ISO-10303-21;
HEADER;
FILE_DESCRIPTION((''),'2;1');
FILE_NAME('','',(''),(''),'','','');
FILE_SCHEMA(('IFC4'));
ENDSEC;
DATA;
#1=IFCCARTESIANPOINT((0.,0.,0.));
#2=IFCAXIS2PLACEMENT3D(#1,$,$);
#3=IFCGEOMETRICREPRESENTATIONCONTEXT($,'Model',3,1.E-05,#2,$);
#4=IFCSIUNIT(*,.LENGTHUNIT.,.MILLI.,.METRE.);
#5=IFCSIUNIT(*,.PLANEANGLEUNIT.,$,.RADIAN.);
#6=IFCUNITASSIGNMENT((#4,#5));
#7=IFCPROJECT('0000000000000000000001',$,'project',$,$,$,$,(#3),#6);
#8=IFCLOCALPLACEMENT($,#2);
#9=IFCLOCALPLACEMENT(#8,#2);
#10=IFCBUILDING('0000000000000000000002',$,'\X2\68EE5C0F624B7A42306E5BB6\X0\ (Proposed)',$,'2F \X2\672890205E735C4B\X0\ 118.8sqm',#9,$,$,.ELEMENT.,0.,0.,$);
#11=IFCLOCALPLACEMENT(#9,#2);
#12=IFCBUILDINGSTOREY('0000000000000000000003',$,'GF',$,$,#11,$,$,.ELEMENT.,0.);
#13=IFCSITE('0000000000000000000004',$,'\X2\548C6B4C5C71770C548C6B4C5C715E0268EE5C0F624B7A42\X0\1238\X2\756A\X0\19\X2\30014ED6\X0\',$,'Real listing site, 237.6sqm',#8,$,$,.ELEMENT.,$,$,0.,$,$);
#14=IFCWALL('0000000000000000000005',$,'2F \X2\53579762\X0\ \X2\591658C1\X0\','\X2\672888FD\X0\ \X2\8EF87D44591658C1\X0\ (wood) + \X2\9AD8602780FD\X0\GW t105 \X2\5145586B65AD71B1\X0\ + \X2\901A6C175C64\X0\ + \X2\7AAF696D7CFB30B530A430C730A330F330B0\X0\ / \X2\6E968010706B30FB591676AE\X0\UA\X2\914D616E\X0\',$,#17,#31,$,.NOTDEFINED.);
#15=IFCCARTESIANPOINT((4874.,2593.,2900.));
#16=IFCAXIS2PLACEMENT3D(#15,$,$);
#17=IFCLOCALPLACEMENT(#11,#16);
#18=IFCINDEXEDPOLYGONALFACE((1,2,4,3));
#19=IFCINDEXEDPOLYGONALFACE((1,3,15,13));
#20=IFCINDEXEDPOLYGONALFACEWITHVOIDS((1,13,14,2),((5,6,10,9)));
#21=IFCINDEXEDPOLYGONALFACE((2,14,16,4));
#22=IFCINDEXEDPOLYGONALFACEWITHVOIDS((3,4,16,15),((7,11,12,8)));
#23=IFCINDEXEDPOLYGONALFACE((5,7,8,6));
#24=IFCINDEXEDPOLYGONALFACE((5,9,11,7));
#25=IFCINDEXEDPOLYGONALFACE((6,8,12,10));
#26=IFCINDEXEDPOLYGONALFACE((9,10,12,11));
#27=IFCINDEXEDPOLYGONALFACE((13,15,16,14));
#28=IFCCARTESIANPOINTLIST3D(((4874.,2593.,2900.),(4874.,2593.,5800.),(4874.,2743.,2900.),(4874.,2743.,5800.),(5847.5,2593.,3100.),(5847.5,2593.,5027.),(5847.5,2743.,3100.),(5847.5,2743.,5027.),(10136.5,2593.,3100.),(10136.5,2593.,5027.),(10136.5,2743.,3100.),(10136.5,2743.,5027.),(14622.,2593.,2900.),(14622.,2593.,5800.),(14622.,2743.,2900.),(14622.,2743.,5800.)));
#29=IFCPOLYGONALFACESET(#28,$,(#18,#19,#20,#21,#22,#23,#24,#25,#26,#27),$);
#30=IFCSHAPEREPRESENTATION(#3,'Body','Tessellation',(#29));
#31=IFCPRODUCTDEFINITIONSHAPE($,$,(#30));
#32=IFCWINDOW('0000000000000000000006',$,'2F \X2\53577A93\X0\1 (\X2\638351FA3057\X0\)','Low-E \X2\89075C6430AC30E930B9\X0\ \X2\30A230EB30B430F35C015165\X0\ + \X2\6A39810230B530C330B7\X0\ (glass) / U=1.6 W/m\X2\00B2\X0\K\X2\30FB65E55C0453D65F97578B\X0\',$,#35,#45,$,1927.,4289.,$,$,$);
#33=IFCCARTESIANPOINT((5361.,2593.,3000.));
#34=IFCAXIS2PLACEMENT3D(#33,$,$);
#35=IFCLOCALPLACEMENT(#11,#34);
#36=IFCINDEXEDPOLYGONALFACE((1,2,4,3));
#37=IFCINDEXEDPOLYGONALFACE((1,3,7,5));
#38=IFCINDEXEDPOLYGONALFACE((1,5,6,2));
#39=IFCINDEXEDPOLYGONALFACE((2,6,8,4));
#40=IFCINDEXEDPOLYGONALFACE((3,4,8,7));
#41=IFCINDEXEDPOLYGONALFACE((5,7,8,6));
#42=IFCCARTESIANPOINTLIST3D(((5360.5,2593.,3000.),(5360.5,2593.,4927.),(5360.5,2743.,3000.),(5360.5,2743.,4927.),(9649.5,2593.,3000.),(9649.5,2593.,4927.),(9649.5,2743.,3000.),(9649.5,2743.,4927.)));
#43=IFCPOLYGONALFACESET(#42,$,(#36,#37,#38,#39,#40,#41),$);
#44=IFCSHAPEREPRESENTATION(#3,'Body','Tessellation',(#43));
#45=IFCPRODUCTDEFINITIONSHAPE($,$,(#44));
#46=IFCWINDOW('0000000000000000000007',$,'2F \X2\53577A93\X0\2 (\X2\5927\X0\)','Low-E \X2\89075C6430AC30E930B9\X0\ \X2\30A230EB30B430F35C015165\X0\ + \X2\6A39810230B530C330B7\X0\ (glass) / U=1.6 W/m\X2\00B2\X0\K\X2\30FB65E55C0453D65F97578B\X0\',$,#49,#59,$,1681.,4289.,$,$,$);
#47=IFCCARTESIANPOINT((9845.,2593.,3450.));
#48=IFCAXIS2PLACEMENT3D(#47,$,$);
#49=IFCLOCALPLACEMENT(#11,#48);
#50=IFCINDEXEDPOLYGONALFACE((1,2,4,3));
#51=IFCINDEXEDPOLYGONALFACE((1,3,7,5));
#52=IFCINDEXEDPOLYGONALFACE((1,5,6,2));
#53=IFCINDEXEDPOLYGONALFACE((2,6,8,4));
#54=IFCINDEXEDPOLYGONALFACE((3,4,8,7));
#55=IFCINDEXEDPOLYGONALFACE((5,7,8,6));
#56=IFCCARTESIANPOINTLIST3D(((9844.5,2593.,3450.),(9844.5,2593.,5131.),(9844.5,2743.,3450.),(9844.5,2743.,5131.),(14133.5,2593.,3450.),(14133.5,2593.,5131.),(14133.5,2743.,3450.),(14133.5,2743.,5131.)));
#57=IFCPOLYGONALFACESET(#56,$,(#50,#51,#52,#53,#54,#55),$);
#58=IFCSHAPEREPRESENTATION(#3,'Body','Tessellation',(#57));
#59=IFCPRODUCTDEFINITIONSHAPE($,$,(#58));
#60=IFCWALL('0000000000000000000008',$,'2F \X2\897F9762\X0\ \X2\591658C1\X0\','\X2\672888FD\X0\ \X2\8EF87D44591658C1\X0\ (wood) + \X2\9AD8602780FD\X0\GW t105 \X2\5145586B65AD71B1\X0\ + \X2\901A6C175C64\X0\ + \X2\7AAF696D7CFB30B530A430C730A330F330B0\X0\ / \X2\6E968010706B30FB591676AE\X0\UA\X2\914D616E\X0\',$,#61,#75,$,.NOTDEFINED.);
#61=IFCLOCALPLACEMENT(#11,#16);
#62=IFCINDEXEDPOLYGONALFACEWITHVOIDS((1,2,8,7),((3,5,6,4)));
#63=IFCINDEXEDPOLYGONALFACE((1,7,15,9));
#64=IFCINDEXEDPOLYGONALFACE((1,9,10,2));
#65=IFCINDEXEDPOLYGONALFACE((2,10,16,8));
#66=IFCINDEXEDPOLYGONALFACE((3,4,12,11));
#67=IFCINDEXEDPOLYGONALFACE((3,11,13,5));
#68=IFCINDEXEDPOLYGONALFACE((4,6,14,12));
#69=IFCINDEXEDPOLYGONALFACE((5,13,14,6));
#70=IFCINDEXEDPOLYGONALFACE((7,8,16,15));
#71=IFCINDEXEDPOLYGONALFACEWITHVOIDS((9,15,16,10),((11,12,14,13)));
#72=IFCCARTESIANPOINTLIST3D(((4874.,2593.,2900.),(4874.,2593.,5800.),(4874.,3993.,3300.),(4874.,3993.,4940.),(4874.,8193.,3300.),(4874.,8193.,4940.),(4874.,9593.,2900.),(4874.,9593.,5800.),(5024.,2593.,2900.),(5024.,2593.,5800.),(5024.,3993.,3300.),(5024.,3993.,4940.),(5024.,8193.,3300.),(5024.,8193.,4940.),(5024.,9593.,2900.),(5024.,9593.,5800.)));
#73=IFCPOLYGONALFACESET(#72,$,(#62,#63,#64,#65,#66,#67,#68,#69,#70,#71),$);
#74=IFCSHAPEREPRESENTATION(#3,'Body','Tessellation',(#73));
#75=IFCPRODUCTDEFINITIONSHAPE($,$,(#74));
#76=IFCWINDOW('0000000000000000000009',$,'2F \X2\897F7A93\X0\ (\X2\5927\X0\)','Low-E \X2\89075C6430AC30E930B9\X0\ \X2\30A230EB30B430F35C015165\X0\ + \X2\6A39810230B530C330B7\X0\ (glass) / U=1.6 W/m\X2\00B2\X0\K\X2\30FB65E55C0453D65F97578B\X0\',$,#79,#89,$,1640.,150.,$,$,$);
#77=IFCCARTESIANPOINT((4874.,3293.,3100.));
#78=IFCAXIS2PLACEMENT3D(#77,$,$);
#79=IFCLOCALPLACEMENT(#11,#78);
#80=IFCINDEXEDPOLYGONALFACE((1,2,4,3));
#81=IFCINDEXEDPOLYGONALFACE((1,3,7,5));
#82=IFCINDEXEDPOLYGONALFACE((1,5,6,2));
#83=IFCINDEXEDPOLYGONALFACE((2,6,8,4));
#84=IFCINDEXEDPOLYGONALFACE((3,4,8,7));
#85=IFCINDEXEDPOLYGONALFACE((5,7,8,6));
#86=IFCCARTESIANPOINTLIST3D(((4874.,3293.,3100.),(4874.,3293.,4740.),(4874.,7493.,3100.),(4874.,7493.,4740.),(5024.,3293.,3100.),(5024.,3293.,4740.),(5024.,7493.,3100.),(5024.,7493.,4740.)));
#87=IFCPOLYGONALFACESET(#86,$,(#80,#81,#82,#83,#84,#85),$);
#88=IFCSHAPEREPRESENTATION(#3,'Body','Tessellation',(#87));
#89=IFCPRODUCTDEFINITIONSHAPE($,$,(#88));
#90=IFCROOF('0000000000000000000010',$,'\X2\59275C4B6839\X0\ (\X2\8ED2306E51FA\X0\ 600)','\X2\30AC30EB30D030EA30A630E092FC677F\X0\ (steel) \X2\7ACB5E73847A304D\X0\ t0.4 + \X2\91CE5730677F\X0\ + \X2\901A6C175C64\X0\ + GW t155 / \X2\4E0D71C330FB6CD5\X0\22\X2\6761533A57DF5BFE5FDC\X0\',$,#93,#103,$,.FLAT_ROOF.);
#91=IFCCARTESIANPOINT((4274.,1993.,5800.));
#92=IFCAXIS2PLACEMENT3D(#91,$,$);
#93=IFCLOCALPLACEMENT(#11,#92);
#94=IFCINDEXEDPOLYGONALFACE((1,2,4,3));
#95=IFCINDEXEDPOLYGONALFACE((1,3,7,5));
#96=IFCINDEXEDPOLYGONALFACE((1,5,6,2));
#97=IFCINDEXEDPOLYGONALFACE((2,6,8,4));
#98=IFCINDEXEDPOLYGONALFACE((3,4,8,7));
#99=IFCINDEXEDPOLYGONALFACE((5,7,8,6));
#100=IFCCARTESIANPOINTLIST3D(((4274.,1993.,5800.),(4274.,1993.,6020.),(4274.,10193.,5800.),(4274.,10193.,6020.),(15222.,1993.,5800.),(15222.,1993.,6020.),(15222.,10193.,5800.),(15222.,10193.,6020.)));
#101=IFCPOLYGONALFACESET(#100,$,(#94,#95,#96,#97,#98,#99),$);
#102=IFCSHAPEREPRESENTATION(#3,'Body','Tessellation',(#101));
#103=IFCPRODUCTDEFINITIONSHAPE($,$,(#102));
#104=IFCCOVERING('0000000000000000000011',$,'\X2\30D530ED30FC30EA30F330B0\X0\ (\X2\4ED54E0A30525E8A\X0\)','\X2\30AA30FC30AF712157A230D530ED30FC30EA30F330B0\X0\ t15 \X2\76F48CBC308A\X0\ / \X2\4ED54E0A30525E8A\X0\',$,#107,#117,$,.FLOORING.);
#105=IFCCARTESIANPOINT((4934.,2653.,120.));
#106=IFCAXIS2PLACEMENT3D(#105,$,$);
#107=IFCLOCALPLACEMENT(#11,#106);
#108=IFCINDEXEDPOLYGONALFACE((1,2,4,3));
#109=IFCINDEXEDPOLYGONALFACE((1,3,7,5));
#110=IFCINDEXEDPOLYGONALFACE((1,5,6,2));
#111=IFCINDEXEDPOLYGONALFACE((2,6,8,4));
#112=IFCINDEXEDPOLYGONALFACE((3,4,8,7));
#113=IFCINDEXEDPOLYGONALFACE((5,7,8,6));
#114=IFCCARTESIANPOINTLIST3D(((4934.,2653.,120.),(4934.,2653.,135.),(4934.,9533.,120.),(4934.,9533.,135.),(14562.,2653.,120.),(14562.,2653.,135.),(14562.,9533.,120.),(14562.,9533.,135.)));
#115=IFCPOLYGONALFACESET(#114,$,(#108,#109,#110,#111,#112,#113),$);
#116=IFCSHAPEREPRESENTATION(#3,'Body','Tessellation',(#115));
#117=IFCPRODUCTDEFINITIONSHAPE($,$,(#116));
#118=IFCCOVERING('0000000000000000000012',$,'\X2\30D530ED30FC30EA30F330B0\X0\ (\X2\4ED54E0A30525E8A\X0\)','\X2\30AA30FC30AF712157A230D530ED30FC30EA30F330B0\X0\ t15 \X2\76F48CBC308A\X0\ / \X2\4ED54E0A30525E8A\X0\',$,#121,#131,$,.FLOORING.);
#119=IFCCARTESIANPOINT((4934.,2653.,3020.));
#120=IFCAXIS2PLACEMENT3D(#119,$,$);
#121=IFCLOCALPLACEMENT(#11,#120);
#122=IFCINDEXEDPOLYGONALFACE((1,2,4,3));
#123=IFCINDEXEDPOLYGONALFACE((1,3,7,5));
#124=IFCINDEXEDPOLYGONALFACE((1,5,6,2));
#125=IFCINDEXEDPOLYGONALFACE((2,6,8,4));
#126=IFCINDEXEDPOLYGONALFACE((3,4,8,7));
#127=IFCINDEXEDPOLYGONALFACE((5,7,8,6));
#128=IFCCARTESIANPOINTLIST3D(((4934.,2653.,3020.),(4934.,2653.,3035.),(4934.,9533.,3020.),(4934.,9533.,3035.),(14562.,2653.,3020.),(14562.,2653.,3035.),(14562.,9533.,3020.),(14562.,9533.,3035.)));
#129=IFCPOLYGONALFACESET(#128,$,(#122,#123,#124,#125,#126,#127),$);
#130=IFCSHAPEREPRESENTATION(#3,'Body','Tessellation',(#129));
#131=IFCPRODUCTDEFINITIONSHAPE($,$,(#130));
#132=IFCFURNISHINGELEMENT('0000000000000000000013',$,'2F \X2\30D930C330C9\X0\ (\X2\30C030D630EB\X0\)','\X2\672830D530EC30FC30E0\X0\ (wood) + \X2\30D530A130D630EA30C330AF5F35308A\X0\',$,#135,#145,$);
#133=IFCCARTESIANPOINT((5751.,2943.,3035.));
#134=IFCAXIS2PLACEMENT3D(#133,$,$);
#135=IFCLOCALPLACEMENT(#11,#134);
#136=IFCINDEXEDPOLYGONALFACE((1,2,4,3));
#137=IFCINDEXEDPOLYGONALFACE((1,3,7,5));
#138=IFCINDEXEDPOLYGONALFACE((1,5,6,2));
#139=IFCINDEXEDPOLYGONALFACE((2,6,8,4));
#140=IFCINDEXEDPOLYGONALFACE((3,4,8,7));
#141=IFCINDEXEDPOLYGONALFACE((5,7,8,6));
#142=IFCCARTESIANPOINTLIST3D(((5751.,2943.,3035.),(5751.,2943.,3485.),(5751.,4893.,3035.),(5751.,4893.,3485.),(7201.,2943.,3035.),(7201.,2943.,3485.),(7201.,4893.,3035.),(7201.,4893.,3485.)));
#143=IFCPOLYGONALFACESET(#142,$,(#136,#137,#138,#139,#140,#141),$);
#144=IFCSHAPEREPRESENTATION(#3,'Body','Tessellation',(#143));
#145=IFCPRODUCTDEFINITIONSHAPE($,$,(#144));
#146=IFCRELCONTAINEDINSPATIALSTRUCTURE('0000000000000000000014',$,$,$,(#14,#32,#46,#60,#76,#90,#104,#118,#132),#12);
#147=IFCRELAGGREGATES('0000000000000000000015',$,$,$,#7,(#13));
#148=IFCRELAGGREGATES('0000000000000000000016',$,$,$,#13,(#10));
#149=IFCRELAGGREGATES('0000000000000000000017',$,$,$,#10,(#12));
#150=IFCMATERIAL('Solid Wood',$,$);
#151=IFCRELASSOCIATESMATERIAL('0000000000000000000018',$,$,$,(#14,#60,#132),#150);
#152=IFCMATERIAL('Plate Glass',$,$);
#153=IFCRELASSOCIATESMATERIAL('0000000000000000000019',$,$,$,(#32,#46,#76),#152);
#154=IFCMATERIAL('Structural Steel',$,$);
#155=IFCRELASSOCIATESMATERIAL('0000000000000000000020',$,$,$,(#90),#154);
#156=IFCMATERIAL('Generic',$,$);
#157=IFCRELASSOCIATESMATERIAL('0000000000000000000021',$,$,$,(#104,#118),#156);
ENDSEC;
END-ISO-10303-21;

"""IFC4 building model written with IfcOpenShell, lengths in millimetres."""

from ifc_helpers import new_model, si_unit, frame, frame_2d, origin, place, context, project, spatial, rectangle, extrude, material, element, fill, save


model = new_model("IFC4")

# Units and contexts
model_context = context("Model", 3, precision=1e-05, world=origin())
ifc_project = project(units=[si_unit("LENGTHUNIT", "METRE", prefix="MILLI"), si_unit("PLANEANGLEUNIT", "RADIAN")], contexts=[model_context])

# Site, building, storey
site_placement = place(None, origin())
site = spatial("IfcSite", under=ifc_project, at=site_placement, Name="和歌山県和歌山市森小手穂1238番19、他", ObjectType="Real listing site, 237.6sqm", CompositionType="ELEMENT", RefElevation=0.0)
building_placement = place(site_placement, origin())
building = spatial("IfcBuilding", under=site, at=building_placement, Name="森小手穂の家 (Proposed)", ObjectType="2F 木造平屋 118.8sqm", CompositionType="ELEMENT", ElevationOfRefHeight=0.0, ElevationOfTerrain=0.0)
storey_placement = place(building_placement, origin())
storey = spatial("IfcBuildingStorey", under=building, at=storey_placement, Name="GF", CompositionType="ELEMENT", Elevation=0.0)

# Shared definitions
ifc_material_1 = material(Name="Solid Wood")

# Shared definitions
ifc_material_2 = material(Name="Plate Glass")

# Wall, openings, windows
wall_1_placement = place(storey_placement, frame((4874.0, 2593.0, 2900.0)))
wall_1 = element("IfcWall", 1, at=wall_1_placement, inside=storey, material=ifc_material_1, Name="2F 南面 外壁", Description="木製 軸組外壁 (wood) + 高性能GW t105 充填断熱 + 通気層 + 窯業系サイディング / 準耐火・外皮UA配慮", PredefinedType="NOTDEFINED", context=model_context, shape_type="SweptSolid", body=[
    extrude(rectangle(XDim=9748.0, YDim=150.0, at=frame_2d((4874.0, 75.0))), frame((4874.0, 2593.0, 2900.0)), (0.0, 0.0, 1.0), 2900.0),
])
opening_1_placement = place(storey_placement, frame((5361.0, 2593.0, 3000.0)))
opening_1 = element("IfcOpeningElement", 2, at=opening_1_placement, cuts=wall_1, PredefinedType="NOTDEFINED", context=model_context, shape_type="SweptSolid", body=[
    extrude(rectangle(XDim=4289.0, YDim=150.0, at=frame_2d((2144.0, 75.0))), frame((5361.0, 2593.0, 3000.0)), (0.0, 0.0, 1.0), 1927.0),
])
opening_2_placement = place(storey_placement, frame((9845.0, 2593.0, 3450.0)))
opening_2 = element("IfcOpeningElement", 3, at=opening_2_placement, cuts=wall_1, PredefinedType="NOTDEFINED", context=model_context, shape_type="SweptSolid", body=[
    extrude(rectangle(XDim=4289.0, YDim=150.0, at=frame_2d((2144.0, 75.0))), frame((9845.0, 2593.0, 3450.0)), (0.0, 0.0, 1.0), 1681.0),
])
window_1_placement = place(storey_placement, frame((5361.0, 2593.0, 3000.0)))
window_1 = element("IfcWindow", 4, at=window_1_placement, inside=storey, material=ifc_material_2, Name="2F 南窓1 (掃出し)", Description="Low-E 複層ガラス アルゴン封入 + 樹脂サッシ (glass) / U=1.6 W/m²K・日射取得型", OverallHeight=1927.0, OverallWidth=4289.0, context=model_context, shape_type="SweptSolid", body=[
    extrude(rectangle(XDim=4289.0, YDim=150.0, at=frame_2d((2144.0, 75.0))), frame((5361.0, 2593.0, 3000.0)), (0.0, 0.0, 1.0), 1927.0),
])
fill(opening_1, window_1)
window_2_placement = place(storey_placement, frame((9845.0, 2593.0, 3450.0)))
window_2 = element("IfcWindow", 5, at=window_2_placement, inside=storey, material=ifc_material_2, Name="2F 南窓2 (大)", Description="Low-E 複層ガラス アルゴン封入 + 樹脂サッシ (glass) / U=1.6 W/m²K・日射取得型", OverallHeight=1681.0, OverallWidth=4289.0, context=model_context, shape_type="SweptSolid", body=[
    extrude(rectangle(XDim=4289.0, YDim=150.0, at=frame_2d((2144.0, 75.0))), frame((9845.0, 2593.0, 3450.0)), (0.0, 0.0, 1.0), 1681.0),
])
fill(opening_2, window_2)

# Wall, opening, window
wall_2_placement = place(storey_placement, frame((4874.0, 2593.0, 2900.0)))
wall_2 = element("IfcWall", 6, at=wall_2_placement, inside=storey, material=ifc_material_1, Name="2F 西面 外壁", Description="木製 軸組外壁 (wood) + 高性能GW t105 充填断熱 + 通気層 + 窯業系サイディング / 準耐火・外皮UA配慮", PredefinedType="NOTDEFINED", context=model_context, shape_type="SweptSolid", body=[
    extrude(rectangle(XDim=150.0, YDim=7000.0, at=frame_2d((75.0, 3500.0))), frame((4874.0, 2593.0, 2900.0)), (0.0, 0.0, 1.0), 2900.0),
])
opening_3_placement = place(storey_placement, frame((4874.0, 3293.0, 3100.0)))
opening_3 = element("IfcOpeningElement", 7, at=opening_3_placement, cuts=wall_2, PredefinedType="NOTDEFINED", context=model_context, shape_type="SweptSolid", body=[
    extrude(rectangle(XDim=150.0, YDim=4200.0, at=frame_2d((75.0, 2100.0))), frame((4874.0, 3293.0, 3100.0)), (0.0, 0.0, 1.0), 1640.0),
])
window_3_placement = place(storey_placement, frame((4874.0, 3293.0, 3100.0)))
window_3 = element("IfcWindow", 8, at=window_3_placement, inside=storey, material=ifc_material_2, Name="2F 西窓 (大)", Description="Low-E 複層ガラス アルゴン封入 + 樹脂サッシ (glass) / U=1.6 W/m²K・日射取得型", OverallHeight=1640.0, OverallWidth=150.0, context=model_context, shape_type="SweptSolid", body=[
    extrude(rectangle(XDim=150.0, YDim=4200.0, at=frame_2d((75.0, 2100.0))), frame((4874.0, 3293.0, 3100.0)), (0.0, 0.0, 1.0), 1640.0),
])
fill(opening_3, window_3)

# Roof
ifc_material_3 = material(Name="Structural Steel")
roof_placement = place(storey_placement, frame((4274.0, 1993.0, 5800.0)))
element("IfcRoof", 9, at=roof_placement, inside=storey, material=ifc_material_3, Name="大屋根 (軒の出 600)", Description="ガルバリウム鋼板 (steel) 立平葺き t0.4 + 野地板 + 通気層 + GW t155 / 不燃・法22条区域対応", PredefinedType="FLAT_ROOF", context=model_context, shape_type="SweptSolid", body=[
    extrude(rectangle(XDim=10948.0, YDim=8200.0, at=frame_2d((5474.0, 4100.0))), frame((4274.0, 1993.0, 5800.0)), (0.0, 0.0, 1.0), 220.0),
])

# Coverings
ifc_material_4 = material(Name="Generic")
covering_1_placement = place(storey_placement, frame((4934.0, 2653.0, 120.0)))
element("IfcCovering", 10, at=covering_1_placement, inside=storey, material=ifc_material_4, Name="フローリング (仕上げ床)", Description="オーク無垢フローリング t15 直貼り / 仕上げ床", PredefinedType="FLOORING", context=model_context, shape_type="SweptSolid", body=[
    extrude(rectangle(XDim=9628.0, YDim=6880.0, at=frame_2d((4814.0, 3440.0))), frame((4934.0, 2653.0, 120.0)), (0.0, 0.0, 1.0), 15.0),
])
covering_2_placement = place(storey_placement, frame((4934.0, 2653.0, 3020.0)))
element("IfcCovering", 11, at=covering_2_placement, inside=storey, material=ifc_material_4, Name="フローリング (仕上げ床)", Description="オーク無垢フローリング t15 直貼り / 仕上げ床", PredefinedType="FLOORING", context=model_context, shape_type="SweptSolid", body=[
    extrude(rectangle(XDim=9628.0, YDim=6880.0, at=frame_2d((4814.0, 3440.0))), frame((4934.0, 2653.0, 3020.0)), (0.0, 0.0, 1.0), 15.0),
])

# Furnishing element
furnishing_placement = place(storey_placement, frame((5751.0, 2943.0, 3035.0)))
element("IfcFurnishingElement", 12, at=furnishing_placement, inside=storey, material=ifc_material_1, Name="2F ベッド (ダブル)", Description="木フレーム (wood) + ファブリック張り", context=model_context, shape_type="SweptSolid", body=[
    extrude(rectangle(XDim=1450.0, YDim=1950.0, at=frame_2d((725.0, 975.0))), frame((5751.0, 2943.0, 3035.0)), (0.0, 0.0, 1.0), 450.0),
])

save(model, "model.ifc")
